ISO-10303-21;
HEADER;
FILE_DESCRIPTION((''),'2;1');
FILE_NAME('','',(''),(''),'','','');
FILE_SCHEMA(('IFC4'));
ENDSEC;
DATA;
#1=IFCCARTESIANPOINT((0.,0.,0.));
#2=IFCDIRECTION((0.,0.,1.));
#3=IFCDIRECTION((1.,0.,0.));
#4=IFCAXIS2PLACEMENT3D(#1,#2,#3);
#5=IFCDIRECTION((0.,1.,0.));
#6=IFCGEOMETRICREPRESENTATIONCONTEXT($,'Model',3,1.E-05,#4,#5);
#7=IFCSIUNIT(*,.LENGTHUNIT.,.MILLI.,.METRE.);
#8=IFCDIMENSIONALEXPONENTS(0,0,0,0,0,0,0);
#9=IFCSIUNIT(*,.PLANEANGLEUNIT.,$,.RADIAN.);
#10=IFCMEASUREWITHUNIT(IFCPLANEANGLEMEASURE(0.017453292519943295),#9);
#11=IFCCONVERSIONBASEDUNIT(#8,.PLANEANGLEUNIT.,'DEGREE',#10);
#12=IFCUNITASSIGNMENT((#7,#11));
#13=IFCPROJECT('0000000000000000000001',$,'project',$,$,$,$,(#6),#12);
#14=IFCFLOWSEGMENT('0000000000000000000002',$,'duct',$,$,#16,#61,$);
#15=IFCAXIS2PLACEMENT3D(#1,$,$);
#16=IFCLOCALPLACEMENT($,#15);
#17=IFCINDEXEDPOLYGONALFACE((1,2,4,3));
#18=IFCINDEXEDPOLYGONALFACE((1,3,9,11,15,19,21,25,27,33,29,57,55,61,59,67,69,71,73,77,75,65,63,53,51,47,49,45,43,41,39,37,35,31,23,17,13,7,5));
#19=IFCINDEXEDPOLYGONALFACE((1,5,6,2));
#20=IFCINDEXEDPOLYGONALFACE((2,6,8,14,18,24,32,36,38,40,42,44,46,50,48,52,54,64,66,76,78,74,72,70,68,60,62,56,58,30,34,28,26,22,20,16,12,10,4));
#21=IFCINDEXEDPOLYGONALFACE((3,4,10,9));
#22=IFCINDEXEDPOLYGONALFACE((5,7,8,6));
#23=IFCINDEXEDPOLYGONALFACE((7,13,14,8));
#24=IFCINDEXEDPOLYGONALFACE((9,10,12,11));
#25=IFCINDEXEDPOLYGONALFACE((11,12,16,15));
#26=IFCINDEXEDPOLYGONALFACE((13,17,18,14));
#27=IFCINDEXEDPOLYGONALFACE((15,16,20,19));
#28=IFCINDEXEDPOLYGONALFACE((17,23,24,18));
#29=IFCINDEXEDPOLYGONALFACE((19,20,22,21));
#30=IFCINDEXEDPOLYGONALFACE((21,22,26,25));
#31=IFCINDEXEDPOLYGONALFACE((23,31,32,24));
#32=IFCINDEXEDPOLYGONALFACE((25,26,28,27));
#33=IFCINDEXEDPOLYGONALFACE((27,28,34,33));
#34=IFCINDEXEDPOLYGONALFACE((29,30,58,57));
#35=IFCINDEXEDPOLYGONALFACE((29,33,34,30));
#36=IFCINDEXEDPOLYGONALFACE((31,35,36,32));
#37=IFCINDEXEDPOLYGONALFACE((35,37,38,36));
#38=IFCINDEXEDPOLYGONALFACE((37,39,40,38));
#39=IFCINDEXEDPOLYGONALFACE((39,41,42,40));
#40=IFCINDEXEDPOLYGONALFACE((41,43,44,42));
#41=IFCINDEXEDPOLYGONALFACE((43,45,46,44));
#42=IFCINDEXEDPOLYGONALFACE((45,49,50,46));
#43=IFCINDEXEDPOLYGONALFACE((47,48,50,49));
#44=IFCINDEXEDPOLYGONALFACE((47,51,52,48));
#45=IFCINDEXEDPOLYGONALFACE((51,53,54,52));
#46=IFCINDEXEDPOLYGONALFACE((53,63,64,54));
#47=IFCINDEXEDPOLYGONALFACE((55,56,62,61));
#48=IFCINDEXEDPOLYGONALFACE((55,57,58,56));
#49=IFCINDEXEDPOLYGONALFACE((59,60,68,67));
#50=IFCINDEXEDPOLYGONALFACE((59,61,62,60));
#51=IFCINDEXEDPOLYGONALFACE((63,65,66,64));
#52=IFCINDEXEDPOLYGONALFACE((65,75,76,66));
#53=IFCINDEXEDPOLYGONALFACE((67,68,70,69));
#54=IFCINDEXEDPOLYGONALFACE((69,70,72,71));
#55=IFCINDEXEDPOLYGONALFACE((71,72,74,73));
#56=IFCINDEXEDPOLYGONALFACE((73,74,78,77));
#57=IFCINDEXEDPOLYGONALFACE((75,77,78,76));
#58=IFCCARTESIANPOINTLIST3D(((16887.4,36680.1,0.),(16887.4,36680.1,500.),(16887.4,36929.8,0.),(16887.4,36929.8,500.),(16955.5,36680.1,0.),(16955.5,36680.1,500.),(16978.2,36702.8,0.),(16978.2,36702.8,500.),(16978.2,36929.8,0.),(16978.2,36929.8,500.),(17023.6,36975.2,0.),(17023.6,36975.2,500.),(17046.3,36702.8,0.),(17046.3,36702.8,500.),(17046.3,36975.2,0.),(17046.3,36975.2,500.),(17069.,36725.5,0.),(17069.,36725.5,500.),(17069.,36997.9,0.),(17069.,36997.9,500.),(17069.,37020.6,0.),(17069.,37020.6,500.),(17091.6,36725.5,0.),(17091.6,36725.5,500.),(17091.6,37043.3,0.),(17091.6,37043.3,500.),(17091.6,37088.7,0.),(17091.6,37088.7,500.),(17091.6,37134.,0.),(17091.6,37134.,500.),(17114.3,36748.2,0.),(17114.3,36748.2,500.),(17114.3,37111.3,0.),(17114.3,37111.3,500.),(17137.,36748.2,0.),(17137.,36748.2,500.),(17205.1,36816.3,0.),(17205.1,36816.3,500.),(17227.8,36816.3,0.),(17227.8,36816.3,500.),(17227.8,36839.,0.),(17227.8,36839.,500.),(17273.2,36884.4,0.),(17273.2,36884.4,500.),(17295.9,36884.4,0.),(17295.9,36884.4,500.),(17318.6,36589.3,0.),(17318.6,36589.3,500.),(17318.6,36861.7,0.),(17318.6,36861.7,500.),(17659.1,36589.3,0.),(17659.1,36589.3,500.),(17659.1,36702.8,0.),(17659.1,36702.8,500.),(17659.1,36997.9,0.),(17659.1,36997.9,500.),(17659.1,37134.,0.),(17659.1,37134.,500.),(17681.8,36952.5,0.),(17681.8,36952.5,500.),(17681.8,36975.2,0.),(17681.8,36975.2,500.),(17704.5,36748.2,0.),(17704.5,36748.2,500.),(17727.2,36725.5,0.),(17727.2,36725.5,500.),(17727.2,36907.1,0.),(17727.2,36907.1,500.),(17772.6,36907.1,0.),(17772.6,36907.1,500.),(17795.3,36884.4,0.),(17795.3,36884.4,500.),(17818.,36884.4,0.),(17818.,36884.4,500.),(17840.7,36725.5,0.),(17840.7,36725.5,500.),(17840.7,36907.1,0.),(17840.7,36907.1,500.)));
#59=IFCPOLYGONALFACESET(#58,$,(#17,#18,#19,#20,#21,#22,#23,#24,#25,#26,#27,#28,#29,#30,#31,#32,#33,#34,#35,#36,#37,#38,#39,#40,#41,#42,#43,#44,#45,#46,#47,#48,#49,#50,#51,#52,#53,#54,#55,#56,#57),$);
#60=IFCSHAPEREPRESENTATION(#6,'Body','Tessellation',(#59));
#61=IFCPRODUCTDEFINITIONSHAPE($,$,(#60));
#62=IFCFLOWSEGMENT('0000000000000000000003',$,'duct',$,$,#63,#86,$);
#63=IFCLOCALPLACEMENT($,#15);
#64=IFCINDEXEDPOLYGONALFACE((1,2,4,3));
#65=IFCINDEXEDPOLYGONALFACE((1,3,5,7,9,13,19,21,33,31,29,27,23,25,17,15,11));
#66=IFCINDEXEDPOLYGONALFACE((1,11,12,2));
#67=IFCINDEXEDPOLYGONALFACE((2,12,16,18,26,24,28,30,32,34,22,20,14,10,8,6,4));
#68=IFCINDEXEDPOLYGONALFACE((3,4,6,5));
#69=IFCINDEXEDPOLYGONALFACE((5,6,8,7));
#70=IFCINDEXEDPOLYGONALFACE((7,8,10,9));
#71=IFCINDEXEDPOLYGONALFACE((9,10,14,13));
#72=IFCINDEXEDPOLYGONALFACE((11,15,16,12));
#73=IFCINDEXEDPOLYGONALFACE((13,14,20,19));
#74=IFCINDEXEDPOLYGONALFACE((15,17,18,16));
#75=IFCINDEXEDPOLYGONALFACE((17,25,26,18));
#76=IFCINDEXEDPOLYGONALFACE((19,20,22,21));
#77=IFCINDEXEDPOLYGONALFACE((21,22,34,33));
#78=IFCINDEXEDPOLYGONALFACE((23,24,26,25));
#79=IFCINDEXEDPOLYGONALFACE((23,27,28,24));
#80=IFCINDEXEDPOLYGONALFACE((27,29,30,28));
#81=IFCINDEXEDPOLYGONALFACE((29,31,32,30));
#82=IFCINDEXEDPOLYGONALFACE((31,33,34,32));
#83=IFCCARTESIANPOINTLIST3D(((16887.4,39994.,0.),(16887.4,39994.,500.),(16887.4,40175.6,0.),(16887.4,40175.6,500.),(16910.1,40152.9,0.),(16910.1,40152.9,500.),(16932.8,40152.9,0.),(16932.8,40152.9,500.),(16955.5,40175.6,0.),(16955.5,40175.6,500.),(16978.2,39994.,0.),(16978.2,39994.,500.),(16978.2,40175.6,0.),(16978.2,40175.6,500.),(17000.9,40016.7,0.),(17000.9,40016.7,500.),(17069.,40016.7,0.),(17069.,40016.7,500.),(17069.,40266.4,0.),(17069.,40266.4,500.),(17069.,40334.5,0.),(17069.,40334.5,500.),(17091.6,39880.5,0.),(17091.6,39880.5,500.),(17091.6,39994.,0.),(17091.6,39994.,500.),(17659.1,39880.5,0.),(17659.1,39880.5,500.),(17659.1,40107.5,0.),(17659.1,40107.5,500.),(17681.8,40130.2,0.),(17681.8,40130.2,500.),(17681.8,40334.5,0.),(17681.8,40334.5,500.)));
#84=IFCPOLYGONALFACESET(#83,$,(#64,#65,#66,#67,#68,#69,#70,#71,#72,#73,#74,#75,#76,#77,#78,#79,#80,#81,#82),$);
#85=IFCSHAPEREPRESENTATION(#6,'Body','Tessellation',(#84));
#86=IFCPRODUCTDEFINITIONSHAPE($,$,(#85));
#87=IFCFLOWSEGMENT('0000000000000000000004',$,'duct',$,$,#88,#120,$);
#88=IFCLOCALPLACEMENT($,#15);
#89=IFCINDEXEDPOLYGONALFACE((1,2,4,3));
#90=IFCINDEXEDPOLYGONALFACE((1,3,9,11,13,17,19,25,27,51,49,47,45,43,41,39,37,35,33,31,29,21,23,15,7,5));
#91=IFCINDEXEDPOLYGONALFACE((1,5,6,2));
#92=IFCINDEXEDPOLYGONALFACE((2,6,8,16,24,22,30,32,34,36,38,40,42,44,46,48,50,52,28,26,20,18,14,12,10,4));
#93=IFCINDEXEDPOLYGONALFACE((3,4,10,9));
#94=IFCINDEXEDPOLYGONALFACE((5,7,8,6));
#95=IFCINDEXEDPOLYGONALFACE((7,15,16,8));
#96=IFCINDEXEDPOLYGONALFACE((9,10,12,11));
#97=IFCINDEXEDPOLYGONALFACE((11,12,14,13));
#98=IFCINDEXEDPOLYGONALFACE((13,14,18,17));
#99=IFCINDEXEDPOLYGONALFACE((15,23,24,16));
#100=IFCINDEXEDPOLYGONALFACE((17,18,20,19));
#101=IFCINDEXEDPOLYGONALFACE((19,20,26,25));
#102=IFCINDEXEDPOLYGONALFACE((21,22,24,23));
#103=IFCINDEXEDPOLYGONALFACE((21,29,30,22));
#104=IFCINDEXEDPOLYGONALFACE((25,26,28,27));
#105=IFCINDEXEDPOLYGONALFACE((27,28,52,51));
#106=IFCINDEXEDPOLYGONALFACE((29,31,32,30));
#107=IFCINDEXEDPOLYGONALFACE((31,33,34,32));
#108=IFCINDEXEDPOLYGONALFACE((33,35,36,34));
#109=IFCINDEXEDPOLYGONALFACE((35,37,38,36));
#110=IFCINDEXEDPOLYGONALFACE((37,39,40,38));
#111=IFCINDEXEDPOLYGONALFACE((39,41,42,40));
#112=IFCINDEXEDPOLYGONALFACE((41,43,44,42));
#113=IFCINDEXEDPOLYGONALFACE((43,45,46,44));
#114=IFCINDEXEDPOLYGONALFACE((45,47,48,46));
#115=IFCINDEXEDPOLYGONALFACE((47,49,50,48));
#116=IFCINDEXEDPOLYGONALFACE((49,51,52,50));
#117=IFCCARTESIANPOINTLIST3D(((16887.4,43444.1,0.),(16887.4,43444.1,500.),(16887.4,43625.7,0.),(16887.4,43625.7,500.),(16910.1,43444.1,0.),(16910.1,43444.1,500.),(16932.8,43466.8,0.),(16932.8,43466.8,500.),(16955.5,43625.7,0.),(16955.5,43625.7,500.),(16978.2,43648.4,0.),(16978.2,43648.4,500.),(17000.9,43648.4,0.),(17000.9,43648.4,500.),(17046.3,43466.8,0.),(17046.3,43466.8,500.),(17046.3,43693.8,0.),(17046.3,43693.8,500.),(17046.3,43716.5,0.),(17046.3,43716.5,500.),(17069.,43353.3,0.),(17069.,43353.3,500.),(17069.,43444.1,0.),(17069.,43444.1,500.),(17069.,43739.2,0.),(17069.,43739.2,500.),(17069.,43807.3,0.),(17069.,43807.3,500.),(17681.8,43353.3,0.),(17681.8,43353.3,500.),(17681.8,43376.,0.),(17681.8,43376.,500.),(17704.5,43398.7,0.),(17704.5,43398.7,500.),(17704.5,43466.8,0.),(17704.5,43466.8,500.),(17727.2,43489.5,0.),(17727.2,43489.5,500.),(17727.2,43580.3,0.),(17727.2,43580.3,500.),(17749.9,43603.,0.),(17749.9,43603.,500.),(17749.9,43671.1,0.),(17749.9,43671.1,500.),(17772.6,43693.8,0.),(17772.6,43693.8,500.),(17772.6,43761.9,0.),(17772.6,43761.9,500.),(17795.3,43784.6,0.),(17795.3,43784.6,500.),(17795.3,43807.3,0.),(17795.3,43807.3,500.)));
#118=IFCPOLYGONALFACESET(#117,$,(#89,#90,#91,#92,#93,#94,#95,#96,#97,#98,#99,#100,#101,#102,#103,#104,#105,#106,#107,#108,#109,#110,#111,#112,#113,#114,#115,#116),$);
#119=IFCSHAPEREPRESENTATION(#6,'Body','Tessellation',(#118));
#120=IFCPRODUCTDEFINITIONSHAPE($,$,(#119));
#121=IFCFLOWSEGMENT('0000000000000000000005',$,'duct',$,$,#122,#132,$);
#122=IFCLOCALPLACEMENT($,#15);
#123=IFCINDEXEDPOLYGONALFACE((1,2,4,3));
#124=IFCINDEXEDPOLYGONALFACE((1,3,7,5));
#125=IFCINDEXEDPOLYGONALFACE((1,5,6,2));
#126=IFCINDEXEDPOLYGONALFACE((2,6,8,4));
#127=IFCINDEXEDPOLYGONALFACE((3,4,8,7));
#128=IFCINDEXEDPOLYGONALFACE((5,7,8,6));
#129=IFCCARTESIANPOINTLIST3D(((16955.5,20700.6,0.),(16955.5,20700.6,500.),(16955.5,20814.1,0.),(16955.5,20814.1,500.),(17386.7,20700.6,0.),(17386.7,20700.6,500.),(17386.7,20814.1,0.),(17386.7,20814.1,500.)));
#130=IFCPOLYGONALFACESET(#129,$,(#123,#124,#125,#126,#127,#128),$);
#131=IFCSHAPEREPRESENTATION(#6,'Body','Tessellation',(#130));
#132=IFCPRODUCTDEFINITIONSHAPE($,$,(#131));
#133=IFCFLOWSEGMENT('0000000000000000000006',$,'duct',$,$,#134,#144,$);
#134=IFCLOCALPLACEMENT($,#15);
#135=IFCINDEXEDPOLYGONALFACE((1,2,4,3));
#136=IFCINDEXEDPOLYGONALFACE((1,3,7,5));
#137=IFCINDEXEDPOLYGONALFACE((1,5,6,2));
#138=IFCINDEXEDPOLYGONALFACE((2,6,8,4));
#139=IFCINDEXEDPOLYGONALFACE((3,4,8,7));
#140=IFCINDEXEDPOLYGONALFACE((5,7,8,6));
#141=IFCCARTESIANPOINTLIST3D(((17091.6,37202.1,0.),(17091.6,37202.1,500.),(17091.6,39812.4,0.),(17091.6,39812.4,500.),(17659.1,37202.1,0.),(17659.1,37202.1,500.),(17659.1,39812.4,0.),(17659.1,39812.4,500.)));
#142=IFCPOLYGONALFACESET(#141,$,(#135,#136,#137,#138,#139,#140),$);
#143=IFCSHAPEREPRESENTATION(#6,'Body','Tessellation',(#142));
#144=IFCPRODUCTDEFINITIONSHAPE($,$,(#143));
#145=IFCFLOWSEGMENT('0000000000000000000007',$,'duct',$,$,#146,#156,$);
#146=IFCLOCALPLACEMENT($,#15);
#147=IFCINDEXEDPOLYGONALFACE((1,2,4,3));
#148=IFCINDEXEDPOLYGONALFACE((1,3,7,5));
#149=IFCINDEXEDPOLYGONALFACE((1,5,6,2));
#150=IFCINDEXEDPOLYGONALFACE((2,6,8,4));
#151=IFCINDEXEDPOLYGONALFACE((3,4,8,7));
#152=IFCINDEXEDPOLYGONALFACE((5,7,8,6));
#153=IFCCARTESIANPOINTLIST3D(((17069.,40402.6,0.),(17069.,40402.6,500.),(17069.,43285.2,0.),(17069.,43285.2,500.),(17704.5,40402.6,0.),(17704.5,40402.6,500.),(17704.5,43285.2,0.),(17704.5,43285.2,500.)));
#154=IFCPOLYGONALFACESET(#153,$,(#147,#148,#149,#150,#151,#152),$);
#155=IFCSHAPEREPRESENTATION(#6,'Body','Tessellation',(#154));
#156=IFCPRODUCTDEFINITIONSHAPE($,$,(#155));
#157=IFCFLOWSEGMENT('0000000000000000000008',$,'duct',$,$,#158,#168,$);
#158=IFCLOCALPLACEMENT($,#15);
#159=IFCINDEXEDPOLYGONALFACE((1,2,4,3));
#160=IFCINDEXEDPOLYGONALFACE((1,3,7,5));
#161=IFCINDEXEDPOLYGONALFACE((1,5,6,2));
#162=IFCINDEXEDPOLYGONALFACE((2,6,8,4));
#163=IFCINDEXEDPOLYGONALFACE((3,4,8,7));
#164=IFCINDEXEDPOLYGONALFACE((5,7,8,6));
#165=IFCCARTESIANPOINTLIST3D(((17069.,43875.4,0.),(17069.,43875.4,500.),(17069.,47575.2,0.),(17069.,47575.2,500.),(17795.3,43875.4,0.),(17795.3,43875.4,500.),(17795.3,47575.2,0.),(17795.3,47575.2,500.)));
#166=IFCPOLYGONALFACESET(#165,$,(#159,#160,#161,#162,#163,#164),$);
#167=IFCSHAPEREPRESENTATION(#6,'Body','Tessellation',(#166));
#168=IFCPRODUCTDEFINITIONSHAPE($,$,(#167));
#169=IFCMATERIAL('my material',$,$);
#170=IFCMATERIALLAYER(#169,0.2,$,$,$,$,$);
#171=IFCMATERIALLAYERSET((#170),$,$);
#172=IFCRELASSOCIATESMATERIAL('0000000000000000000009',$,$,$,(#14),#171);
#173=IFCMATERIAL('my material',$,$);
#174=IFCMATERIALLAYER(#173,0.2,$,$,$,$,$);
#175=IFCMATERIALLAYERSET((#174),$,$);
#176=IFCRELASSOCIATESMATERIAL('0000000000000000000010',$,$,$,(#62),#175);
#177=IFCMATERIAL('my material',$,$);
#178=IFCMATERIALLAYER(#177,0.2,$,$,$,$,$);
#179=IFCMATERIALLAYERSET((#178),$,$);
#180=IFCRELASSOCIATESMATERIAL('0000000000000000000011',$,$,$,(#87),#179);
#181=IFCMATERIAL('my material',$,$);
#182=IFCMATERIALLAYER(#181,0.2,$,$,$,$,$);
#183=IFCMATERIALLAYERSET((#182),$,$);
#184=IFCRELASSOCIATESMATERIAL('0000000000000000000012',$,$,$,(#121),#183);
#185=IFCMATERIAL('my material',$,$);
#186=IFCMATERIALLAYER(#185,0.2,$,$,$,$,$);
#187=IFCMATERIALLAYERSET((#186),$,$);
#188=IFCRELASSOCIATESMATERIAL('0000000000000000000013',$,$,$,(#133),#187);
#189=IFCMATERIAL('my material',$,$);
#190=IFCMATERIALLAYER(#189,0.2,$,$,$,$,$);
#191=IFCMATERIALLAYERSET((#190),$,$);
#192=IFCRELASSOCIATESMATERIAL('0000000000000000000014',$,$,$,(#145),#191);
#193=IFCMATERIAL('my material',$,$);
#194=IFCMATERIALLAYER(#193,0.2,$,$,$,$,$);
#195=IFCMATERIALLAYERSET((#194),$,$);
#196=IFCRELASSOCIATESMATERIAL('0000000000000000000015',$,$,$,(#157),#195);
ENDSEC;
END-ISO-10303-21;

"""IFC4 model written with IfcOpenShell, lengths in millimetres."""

from ifc_helpers import new_model, entity, si_unit, converted_unit, direction, origin_with_axes, place, context, project, polyline, outline, extrude, material, layer, layer_set, layer_usage, element, save


model = new_model("IFC4")

# Units and contexts
model_context = context("Model", 3, precision=1e-05, world=origin_with_axes(), true_north=direction((0.0, 1.0, 0.0)))
ifc_project = project(units=[si_unit("LENGTHUNIT", "METRE", prefix="MILLI"), converted_unit("PLANEANGLEUNIT", "DEGREE", entity("IfcPlaneAngleMeasure", 0.017453292519943295), si_unit("PLANEANGLEUNIT", "RADIAN"), dimensions=[0, 0, 0, 0, 0, 0, 0])], contexts=[model_context])

# Flow segments
ifc_material_1 = material(Name="my material")
ifc_layer_1 = layer(ifc_material_1, 0.2)
ifc_layer_set_1 = layer_set([ifc_layer_1])
ifc_layer_usage_1 = layer_usage(ifc_layer_set_1, "AXIS2", "POSITIVE", -0.1)
flow_segment_1_placement = place(None, origin_with_axes())
element("IfcFlowSegment", 1, at=flow_segment_1_placement, material=ifc_layer_usage_1, Name="duct", context=model_context, shape_type="SweptSolid", body=[
    extrude(outline(polyline([(16887.4, 36680.1), (16955.5, 36680.1), (16978.2, 36702.8), (17046.3, 36702.8), (17069.0, 36725.5), (17091.6, 36725.5), (17114.3, 36748.2), (17137.0, 36748.2), (17205.1, 36816.3), (17227.8, 36816.3), (17227.8, 36839.0), (17273.2, 36884.4), (17295.9, 36884.4), (17318.6, 36861.7), (17318.6, 36589.3), (17659.1, 36589.3), (17659.1, 36702.8), (17704.5, 36748.2), (17727.2, 36725.5), (17840.7, 36725.5), (17840.7, 36907.1), (17818.0, 36884.4), (17795.3, 36884.4), (17772.6, 36907.1), (17727.2, 36907.1), (17681.8, 36952.5), (17681.8, 36975.2), (17659.1, 36997.9), (17659.1, 37134.0), (17091.6, 37134.0), (17114.3, 37111.3), (17091.6, 37088.7), (17091.6, 37043.3), (17069.0, 37020.6), (17069.0, 36997.9), (17046.3, 36975.2), (17023.6, 36975.2), (16978.2, 36929.8), (16887.4, 36929.8), (16887.4, 36680.1)])), origin_with_axes(), (0.0, 0.0, 1.0), 500.0),
])
ifc_material_2 = material(Name="my material")
ifc_layer_2 = layer(ifc_material_2, 0.2)
ifc_layer_set_2 = layer_set([ifc_layer_2])
ifc_layer_usage_2 = layer_usage(ifc_layer_set_2, "AXIS2", "POSITIVE", -0.1)
flow_segment_2_placement = place(None, origin_with_axes())
element("IfcFlowSegment", 2, at=flow_segment_2_placement, material=ifc_layer_usage_2, Name="duct", context=model_context, shape_type="SweptSolid", body=[
    extrude(outline(polyline([(16887.4, 39994.0), (16978.2, 39994.0), (17000.9, 40016.7), (17069.0, 40016.7), (17091.6, 39994.0), (17091.6, 39880.5), (17659.1, 39880.5), (17659.1, 40107.5), (17681.8, 40130.2), (17681.8, 40334.5), (17069.0, 40334.5), (17069.0, 40266.4), (16978.2, 40175.6), (16955.5, 40175.6), (16932.8, 40152.9), (16910.1, 40152.9), (16887.4, 40175.6), (16887.4, 39994.0)])), origin_with_axes(), (0.0, 0.0, 1.0), 500.0),
])
ifc_material_3 = material(Name="my material")
ifc_layer_3 = layer(ifc_material_3, 0.2)
ifc_layer_set_3 = layer_set([ifc_layer_3])
ifc_layer_usage_3 = layer_usage(ifc_layer_set_3, "AXIS2", "POSITIVE", -0.1)
flow_segment_3_placement = place(None, origin_with_axes())
element("IfcFlowSegment", 3, at=flow_segment_3_placement, material=ifc_layer_usage_3, Name="duct", context=model_context, shape_type="SweptSolid", body=[
    extrude(outline(polyline([(16887.4, 43444.1), (16910.1, 43444.1), (16932.8, 43466.8), (17046.3, 43466.8), (17069.0, 43444.1), (17069.0, 43353.3), (17681.8, 43353.3), (17681.8, 43376.0), (17704.5, 43398.7), (17704.5, 43466.8), (17727.2, 43489.5), (17727.2, 43580.3), (17749.9, 43603.0), (17749.9, 43671.1), (17772.6, 43693.8), (17772.6, 43761.9), (17795.3, 43784.6), (17795.3, 43807.3), (17069.0, 43807.3), (17069.0, 43739.2), (17046.3, 43716.5), (17046.3, 43693.8), (17000.9, 43648.4), (16978.2, 43648.4), (16955.5, 43625.7), (16887.4, 43625.7), (16887.4, 43444.1)])), origin_with_axes(), (0.0, 0.0, 1.0), 500.0),
])
ifc_material_4 = material(Name="my material")
ifc_layer_4 = layer(ifc_material_4, 0.2)
ifc_layer_set_4 = layer_set([ifc_layer_4])
ifc_layer_usage_4 = layer_usage(ifc_layer_set_4, "AXIS2", "POSITIVE", -0.1)
flow_segment_4_placement = place(None, origin_with_axes())
element("IfcFlowSegment", 4, at=flow_segment_4_placement, material=ifc_layer_usage_4, Name="duct", context=model_context, shape_type="SweptSolid", body=[
    extrude(outline(polyline([(16955.5, 20700.6), (17386.7, 20700.6), (17386.7, 20814.1), (16955.5, 20814.1), (16955.5, 20700.6)])), origin_with_axes(), (0.0, 0.0, 1.0), 500.0),
])
ifc_material_5 = material(Name="my material")
ifc_layer_5 = layer(ifc_material_5, 0.2)
ifc_layer_set_5 = layer_set([ifc_layer_5])
ifc_layer_usage_5 = layer_usage(ifc_layer_set_5, "AXIS2", "POSITIVE", -0.1)
flow_segment_5_placement = place(None, origin_with_axes())
element("IfcFlowSegment", 5, at=flow_segment_5_placement, material=ifc_layer_usage_5, Name="duct", context=model_context, shape_type="SweptSolid", body=[
    extrude(outline(polyline([(17091.6, 37202.1), (17659.1, 37202.1), (17659.1, 39812.4), (17091.6, 39812.4), (17091.6, 37202.1)])), origin_with_axes(), (0.0, 0.0, 1.0), 500.0),
])
ifc_material_6 = material(Name="my material")
ifc_layer_6 = layer(ifc_material_6, 0.2)
ifc_layer_set_6 = layer_set([ifc_layer_6])
ifc_layer_usage_6 = layer_usage(ifc_layer_set_6, "AXIS2", "POSITIVE", -0.1)
flow_segment_6_placement = place(None, origin_with_axes())
element("IfcFlowSegment", 6, at=flow_segment_6_placement, material=ifc_layer_usage_6, Name="duct", context=model_context, shape_type="SweptSolid", body=[
    extrude(outline(polyline([(17069.0, 40402.6), (17704.5, 40402.6), (17704.5, 43285.2), (17069.0, 43285.2), (17069.0, 40402.6)])), origin_with_axes(), (0.0, 0.0, 1.0), 500.0),
])
ifc_material_7 = material(Name="my material")
ifc_layer_7 = layer(ifc_material_7, 0.2)
ifc_layer_set_7 = layer_set([ifc_layer_7])
ifc_layer_usage_7 = layer_usage(ifc_layer_set_7, "AXIS2", "POSITIVE", -0.1)
flow_segment_7_placement = place(None, origin_with_axes())
element("IfcFlowSegment", 7, at=flow_segment_7_placement, material=ifc_layer_usage_7, Name="duct", context=model_context, shape_type="SweptSolid", body=[
    extrude(outline(polyline([(17069.0, 43875.4), (17795.3, 43875.4), (17795.3, 47575.2), (17069.0, 47575.2), (17069.0, 43875.4)])), origin_with_axes(), (0.0, 0.0, 1.0), 500.0),
])

save(model, "model.ifc")
